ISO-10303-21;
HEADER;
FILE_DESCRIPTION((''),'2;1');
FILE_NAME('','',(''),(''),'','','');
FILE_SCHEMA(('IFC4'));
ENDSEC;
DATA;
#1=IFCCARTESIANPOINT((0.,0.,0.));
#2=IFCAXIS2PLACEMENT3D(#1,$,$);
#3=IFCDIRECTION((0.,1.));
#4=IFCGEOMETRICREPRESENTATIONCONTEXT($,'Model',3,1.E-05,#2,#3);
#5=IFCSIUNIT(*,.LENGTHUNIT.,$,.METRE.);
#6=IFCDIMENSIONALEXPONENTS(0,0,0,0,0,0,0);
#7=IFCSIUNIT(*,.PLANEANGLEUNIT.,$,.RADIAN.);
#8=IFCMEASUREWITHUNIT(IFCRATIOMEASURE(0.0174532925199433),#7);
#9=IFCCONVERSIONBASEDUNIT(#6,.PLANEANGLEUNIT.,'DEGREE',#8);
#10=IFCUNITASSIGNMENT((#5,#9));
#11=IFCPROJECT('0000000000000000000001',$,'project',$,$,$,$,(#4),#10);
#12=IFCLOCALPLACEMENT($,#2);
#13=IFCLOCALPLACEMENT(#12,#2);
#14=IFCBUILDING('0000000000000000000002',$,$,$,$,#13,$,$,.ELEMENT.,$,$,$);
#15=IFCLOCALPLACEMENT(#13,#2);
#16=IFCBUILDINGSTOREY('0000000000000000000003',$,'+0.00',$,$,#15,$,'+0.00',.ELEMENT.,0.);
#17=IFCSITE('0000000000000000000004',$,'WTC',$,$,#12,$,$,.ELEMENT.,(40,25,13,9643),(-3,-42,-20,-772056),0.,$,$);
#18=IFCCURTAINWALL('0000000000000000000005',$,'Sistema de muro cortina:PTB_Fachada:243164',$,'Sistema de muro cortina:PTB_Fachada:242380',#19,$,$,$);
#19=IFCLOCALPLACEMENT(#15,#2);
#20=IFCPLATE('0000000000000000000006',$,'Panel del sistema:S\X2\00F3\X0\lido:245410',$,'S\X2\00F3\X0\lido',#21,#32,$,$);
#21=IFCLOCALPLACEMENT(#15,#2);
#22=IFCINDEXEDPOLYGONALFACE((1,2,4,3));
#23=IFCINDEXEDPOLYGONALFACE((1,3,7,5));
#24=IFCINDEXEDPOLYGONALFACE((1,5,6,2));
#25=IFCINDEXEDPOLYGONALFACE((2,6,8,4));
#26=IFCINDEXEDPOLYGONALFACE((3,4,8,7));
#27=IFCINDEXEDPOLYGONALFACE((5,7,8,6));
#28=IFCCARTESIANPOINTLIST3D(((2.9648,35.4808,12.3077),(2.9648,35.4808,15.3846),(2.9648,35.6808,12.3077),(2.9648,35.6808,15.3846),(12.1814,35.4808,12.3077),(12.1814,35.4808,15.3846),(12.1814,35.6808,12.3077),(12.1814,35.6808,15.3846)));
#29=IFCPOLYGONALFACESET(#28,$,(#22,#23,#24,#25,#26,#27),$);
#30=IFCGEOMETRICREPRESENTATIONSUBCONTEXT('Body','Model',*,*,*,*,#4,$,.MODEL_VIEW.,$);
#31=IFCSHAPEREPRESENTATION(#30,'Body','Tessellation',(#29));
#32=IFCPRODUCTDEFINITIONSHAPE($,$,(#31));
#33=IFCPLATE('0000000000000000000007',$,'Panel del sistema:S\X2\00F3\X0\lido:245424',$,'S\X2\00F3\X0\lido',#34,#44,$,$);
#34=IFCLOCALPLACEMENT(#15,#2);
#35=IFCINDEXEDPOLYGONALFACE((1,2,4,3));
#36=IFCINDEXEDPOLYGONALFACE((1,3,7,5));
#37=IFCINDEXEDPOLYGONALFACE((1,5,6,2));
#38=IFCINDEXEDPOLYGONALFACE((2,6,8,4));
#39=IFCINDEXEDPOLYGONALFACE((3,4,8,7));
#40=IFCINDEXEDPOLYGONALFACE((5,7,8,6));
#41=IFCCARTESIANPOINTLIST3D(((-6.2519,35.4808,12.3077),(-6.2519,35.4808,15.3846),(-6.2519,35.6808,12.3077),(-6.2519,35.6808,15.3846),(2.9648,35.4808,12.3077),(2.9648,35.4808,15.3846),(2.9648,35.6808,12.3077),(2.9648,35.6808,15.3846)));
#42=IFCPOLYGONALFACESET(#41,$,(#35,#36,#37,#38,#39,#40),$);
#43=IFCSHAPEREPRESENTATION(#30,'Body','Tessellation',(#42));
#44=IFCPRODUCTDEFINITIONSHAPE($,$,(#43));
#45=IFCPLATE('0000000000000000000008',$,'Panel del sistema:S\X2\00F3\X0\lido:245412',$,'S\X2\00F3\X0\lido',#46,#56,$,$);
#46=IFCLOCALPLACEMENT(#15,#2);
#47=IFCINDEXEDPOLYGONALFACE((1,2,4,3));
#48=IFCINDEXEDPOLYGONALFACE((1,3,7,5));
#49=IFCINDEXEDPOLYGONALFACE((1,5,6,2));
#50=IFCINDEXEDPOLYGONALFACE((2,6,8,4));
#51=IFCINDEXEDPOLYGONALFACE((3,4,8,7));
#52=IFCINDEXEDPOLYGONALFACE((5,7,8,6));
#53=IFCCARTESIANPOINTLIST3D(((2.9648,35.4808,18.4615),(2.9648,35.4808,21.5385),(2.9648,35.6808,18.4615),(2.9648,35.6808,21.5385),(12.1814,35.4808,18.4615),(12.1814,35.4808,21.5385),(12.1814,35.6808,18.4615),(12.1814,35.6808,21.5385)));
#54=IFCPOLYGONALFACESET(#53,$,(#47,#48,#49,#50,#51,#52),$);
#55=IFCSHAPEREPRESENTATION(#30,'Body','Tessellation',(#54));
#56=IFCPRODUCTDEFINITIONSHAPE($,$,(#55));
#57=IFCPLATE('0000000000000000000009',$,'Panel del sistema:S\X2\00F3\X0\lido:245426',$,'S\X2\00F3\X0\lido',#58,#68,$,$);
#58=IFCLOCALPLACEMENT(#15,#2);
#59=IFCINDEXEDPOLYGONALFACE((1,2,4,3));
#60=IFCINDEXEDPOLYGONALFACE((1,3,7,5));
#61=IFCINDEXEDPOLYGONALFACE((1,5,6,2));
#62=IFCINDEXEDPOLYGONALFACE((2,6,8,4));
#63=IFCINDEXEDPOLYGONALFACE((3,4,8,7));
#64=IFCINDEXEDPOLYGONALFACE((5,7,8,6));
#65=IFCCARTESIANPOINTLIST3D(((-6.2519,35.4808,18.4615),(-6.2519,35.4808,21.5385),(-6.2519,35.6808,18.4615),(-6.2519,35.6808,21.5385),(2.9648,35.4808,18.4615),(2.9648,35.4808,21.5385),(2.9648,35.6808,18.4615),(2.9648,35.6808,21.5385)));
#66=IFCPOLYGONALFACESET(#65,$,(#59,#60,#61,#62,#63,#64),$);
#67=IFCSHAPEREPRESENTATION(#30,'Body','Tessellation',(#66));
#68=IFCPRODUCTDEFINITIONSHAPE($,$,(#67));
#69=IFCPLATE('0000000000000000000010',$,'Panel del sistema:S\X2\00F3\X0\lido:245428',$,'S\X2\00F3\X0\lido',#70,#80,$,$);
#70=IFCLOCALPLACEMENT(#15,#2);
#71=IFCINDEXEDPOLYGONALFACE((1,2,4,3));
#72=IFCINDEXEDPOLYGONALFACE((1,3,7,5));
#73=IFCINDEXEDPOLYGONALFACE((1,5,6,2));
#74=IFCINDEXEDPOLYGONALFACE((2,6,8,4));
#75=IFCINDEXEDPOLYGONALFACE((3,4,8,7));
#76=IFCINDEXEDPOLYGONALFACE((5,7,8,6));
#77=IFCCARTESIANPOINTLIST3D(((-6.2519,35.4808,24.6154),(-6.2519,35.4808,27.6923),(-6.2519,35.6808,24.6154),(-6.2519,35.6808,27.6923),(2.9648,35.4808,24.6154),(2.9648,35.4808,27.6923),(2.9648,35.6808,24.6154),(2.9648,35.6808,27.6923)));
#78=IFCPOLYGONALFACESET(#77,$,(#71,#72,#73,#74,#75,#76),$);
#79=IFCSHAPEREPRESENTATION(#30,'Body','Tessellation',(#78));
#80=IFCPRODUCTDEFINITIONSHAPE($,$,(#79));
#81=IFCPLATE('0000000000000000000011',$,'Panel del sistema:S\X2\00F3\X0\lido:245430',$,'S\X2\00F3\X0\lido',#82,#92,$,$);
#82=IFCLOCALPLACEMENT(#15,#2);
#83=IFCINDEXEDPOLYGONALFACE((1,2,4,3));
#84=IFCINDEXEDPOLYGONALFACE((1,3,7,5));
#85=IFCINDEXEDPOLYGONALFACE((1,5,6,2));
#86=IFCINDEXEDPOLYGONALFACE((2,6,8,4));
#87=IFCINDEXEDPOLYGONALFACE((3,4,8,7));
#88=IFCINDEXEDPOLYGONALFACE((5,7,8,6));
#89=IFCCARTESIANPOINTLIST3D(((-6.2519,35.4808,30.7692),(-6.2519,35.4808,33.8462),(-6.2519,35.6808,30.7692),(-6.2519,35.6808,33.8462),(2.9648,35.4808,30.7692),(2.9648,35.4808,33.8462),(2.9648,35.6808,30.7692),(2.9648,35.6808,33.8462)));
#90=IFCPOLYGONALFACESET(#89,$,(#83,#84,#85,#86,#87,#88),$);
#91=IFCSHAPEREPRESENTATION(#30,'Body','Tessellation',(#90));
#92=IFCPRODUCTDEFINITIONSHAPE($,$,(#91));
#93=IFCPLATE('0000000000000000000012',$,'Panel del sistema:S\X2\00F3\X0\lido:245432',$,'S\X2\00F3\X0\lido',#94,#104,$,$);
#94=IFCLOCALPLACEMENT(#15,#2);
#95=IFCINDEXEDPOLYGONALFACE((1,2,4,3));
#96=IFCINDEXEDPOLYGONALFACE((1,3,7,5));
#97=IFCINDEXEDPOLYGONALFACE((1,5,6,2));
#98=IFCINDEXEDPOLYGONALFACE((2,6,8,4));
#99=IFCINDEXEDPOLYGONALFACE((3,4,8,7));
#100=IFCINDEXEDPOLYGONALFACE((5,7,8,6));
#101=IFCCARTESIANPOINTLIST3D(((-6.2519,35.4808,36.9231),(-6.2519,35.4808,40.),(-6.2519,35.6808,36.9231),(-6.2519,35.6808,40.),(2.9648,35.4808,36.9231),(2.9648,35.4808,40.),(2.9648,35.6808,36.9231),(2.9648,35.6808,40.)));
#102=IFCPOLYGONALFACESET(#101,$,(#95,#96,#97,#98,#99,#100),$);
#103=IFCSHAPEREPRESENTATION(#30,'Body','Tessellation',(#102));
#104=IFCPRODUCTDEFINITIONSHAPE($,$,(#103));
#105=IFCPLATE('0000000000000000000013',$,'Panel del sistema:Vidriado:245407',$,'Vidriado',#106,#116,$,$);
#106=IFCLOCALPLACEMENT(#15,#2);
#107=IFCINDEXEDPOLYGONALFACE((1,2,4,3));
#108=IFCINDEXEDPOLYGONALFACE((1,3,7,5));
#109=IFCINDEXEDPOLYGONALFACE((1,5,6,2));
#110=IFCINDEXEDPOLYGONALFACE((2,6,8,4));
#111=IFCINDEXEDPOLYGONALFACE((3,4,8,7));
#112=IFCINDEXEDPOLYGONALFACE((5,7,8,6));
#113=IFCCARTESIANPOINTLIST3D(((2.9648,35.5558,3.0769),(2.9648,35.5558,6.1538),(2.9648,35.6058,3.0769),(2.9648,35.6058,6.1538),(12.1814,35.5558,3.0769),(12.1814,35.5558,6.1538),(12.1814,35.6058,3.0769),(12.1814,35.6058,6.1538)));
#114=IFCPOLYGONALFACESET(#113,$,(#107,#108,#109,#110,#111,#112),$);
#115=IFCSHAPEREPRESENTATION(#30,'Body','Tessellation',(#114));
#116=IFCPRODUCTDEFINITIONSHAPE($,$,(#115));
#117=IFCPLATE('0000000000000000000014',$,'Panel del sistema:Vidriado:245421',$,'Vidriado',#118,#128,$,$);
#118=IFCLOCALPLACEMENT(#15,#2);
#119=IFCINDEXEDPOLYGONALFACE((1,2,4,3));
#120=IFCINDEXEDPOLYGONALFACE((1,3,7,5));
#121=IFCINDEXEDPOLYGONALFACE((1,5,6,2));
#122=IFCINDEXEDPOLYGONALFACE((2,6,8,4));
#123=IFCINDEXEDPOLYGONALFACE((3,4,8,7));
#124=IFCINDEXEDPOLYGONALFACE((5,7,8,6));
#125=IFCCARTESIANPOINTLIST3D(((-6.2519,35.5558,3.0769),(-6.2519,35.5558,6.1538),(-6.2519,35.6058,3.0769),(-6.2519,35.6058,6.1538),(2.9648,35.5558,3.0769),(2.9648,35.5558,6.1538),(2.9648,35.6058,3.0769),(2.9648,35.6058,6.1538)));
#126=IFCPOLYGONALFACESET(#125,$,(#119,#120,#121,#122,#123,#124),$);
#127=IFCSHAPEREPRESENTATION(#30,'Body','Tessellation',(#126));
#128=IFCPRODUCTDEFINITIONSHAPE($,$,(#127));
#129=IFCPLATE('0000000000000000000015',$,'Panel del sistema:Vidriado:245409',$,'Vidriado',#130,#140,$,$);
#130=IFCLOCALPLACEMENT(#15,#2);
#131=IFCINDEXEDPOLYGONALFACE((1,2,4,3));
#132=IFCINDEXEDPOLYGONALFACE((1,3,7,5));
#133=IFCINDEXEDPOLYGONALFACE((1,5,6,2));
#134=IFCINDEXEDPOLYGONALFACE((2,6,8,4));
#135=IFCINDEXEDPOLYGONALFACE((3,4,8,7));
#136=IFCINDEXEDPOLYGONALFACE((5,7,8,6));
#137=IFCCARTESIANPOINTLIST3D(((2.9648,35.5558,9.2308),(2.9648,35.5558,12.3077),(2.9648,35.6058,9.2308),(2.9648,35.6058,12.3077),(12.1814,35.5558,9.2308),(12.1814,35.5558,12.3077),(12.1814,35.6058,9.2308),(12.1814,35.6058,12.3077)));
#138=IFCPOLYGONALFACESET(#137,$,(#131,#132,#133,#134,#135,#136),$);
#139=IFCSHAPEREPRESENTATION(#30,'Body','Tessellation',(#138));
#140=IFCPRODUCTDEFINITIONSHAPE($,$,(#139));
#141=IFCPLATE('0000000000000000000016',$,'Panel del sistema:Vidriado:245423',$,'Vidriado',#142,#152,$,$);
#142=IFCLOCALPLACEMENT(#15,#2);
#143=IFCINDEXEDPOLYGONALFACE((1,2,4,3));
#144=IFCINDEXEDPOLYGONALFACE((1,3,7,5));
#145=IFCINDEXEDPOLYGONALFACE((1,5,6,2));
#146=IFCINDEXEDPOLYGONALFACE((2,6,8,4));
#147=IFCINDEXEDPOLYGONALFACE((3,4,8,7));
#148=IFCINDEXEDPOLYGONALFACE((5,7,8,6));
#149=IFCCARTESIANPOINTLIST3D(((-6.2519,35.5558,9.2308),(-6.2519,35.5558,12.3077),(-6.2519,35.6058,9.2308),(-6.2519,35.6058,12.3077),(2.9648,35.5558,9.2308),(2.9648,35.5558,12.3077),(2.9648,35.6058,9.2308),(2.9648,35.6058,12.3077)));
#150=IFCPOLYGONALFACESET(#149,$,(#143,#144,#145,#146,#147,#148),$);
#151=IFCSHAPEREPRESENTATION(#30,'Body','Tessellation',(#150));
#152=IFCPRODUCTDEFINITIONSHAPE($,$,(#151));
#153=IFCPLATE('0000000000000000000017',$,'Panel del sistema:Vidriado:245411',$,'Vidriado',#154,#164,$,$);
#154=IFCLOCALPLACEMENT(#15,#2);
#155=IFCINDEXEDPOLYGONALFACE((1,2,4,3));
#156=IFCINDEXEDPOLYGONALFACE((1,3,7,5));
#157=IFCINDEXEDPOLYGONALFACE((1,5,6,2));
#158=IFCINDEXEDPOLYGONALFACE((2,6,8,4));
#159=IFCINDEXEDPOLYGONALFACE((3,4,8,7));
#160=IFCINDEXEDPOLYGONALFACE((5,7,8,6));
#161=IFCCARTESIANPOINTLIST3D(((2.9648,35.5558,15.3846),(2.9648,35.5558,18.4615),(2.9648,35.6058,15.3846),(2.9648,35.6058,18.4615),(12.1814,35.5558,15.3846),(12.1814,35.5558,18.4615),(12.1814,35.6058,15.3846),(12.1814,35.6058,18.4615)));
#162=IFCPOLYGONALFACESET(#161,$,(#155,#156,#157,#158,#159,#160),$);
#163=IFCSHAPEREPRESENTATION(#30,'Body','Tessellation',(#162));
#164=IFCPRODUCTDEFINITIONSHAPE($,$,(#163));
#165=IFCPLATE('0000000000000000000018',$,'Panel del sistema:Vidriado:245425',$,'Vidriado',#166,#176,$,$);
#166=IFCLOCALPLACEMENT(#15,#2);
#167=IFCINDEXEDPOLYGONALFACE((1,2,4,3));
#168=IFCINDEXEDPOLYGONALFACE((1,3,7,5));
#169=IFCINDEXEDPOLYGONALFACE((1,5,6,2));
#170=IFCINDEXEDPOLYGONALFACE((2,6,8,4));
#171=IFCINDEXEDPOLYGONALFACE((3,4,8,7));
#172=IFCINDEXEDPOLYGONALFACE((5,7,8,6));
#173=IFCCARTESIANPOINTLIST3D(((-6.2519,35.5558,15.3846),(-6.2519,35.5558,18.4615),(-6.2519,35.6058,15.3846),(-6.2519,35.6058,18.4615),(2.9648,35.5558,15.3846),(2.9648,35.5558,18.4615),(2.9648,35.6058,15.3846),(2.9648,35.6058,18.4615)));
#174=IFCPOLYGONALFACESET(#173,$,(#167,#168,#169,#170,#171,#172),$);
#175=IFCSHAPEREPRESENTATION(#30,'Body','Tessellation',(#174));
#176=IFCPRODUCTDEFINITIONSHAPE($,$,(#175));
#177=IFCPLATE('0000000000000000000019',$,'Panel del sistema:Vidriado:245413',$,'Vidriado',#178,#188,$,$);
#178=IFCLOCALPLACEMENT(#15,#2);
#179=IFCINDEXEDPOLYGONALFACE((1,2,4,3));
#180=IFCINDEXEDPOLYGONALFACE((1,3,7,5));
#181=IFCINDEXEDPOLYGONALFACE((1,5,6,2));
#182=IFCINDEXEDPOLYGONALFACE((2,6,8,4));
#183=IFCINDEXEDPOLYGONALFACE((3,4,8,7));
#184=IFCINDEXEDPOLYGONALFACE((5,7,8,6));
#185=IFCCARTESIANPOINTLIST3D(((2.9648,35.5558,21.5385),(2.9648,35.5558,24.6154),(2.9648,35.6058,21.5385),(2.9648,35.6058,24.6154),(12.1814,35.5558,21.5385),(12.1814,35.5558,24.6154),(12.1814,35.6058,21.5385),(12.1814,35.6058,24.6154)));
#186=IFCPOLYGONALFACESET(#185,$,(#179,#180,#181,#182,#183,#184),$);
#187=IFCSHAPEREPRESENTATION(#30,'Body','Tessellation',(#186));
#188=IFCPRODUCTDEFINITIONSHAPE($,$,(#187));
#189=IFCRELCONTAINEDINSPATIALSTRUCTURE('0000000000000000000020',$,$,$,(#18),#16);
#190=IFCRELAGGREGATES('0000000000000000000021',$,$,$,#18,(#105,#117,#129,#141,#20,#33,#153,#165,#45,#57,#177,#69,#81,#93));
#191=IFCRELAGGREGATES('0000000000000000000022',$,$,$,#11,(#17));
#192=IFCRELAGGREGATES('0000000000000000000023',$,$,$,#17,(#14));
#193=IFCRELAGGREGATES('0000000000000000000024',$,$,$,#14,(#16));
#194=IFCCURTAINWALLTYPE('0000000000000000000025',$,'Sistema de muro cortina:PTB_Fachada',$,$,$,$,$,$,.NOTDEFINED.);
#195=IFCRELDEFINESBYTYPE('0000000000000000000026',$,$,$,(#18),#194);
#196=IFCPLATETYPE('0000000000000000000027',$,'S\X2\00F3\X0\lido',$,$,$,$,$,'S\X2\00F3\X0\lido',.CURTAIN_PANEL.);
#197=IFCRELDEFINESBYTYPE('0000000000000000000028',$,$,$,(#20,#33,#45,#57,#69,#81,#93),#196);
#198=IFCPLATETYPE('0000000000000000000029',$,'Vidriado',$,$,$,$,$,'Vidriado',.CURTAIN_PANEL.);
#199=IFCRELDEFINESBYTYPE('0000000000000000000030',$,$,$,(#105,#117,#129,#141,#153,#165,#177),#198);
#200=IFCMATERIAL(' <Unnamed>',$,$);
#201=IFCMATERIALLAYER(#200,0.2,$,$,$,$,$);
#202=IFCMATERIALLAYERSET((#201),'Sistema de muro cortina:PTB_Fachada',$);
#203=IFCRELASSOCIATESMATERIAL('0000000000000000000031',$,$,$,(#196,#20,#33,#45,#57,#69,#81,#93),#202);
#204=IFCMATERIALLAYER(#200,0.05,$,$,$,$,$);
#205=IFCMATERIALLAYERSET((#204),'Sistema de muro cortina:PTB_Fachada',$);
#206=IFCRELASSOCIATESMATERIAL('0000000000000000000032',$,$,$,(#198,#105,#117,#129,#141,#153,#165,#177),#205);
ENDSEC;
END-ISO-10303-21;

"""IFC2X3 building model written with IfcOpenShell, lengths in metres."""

from ifc_helpers import new_model, entity, si_unit, converted_unit, direction, frame, origin, origin_2d_with_axis, place, context, subcontext, project, spatial, rectangle, extrude, source, transform, mapped, material, layer, layer_set, layer_usage, type_object, type_shapes, element, aggregate, save


model = new_model("IFC2X3")

# Units and contexts
model_context = context("Model", 3, precision=1e-05, world=origin(), true_north=direction((0.0, 1.0)))
body_context = subcontext(model_context, "Body", "Model", "MODEL_VIEW")
ifc_project = project(units=[si_unit("LENGTHUNIT", "METRE"), converted_unit("PLANEANGLEUNIT", "DEGREE", entity("IfcRatioMeasure", 0.0174532925199433), si_unit("PLANEANGLEUNIT", "RADIAN"), dimensions=[0, 0, 0, 0, 0, 0, 0])], contexts=[model_context])

# Site, building, storey
site_placement = place(None, origin())
site = spatial("IfcSite", under=ifc_project, at=site_placement, Name="WTC", CompositionType="ELEMENT", RefLatitude=(40, 25, 13, 9643), RefLongitude=(-3, -42, -20, -772056), RefElevation=0.0)
building_placement = place(site_placement, origin())
building = spatial("IfcBuilding", under=site, at=building_placement, CompositionType="ELEMENT")
storey_placement = place(building_placement, origin())
storey = spatial("IfcBuildingStorey", under=building, at=storey_placement, Name="+0.00", LongName="+0.00", CompositionType="ELEMENT", Elevation=0.0)

# Curtain wall, plates
curtain_wall_type = type_object("IfcCurtainWallType", Name="Sistema de muro cortina:PTB_Fachada", PredefinedType="NOTDEFINED")
ifc_material_1 = material(Name=" <Unnamed>")
ifc_layer_1 = layer(ifc_material_1, 0.2)
ifc_layer_set_1 = layer_set([ifc_layer_1], Name="Sistema de muro cortina:PTB_Fachada")
ifc_layer_2 = layer(ifc_material_1, 0.05)
ifc_layer_set_2 = layer_set([ifc_layer_2], Name="Sistema de muro cortina:PTB_Fachada")
curtain_wall_1_placement = place(storey_placement, origin())
curtain_wall_1 = element("IfcCurtainWall", 1, at=curtain_wall_1_placement, inside=storey, type_object=curtain_wall_type, Name="Sistema de muro cortina:PTB_Fachada:243164", ObjectType="Sistema de muro cortina:PTB_Fachada:242380")
plate_type_1 = type_object("IfcPlateType", Name="Sólido", ElementType="Sólido", PredefinedType="CURTAIN_PANEL", material=ifc_layer_set_1)
shared_shape_1 = source(origin(), body_context, "Body", "SweptSolid", [
    extrude(rectangle(XDim=0.2, YDim=9.2166, at=origin_2d_with_axis()), frame((0.0, 0.0, 0.0), z_axis=(0.0, 0.0, 1.0), x_axis=(0.0, 1.0, 0.0)), (0.0, 0.0, 1.0), 3.0769),
])
type_shapes(plate_type_1, [shared_shape_1])
ifc_layer_usage_1 = layer_usage(ifc_layer_set_1, "AXIS3", "POSITIVE", 0.0)
plate_1_placement = place(curtain_wall_1_placement, frame((7.5731, 35.5808, 12.3077), z_axis=(0.0, 0.0, 1.0), x_axis=(-1.0, 0.0, 0.0)))
plate_1 = element("IfcPlate", 2, at=plate_1_placement, type_object=plate_type_1, material=ifc_layer_usage_1, Name="Panel del sistema:Sólido:245410", ObjectType="Sólido", context=body_context, shape_type="MappedRepresentation", body=[
    mapped(shared_shape_1, transform((0.0, 0.0, 0.0), scale=1.0)),
])
ifc_layer_usage_2 = layer_usage(ifc_layer_set_1, "AXIS3", "POSITIVE", 0.0)
plate_2_placement = place(curtain_wall_1_placement, frame((-1.6436, 35.5808, 12.3077), z_axis=(0.0, 0.0, 1.0), x_axis=(-1.0, 0.0, 0.0)))
plate_2 = element("IfcPlate", 3, at=plate_2_placement, type_object=plate_type_1, material=ifc_layer_usage_2, Name="Panel del sistema:Sólido:245424", ObjectType="Sólido", context=body_context, shape_type="MappedRepresentation", body=[
    mapped(shared_shape_1, transform((0.0, 0.0, 0.0), scale=1.0)),
])
ifc_layer_usage_3 = layer_usage(ifc_layer_set_1, "AXIS3", "POSITIVE", 0.0)
plate_3_placement = place(curtain_wall_1_placement, frame((7.5731, 35.5808, 18.4615), z_axis=(0.0, 0.0, 1.0), x_axis=(-1.0, 0.0, 0.0)))
plate_3 = element("IfcPlate", 4, at=plate_3_placement, type_object=plate_type_1, material=ifc_layer_usage_3, Name="Panel del sistema:Sólido:245412", ObjectType="Sólido", context=body_context, shape_type="MappedRepresentation", body=[
    mapped(shared_shape_1, transform((0.0, 0.0, 0.0), scale=1.0)),
])
ifc_layer_usage_4 = layer_usage(ifc_layer_set_1, "AXIS3", "POSITIVE", 0.0)
plate_4_placement = place(curtain_wall_1_placement, frame((-1.6436, 35.5808, 18.4615), z_axis=(0.0, 0.0, 1.0), x_axis=(-1.0, 0.0, 0.0)))
plate_4 = element("IfcPlate", 5, at=plate_4_placement, type_object=plate_type_1, material=ifc_layer_usage_4, Name="Panel del sistema:Sólido:245426", ObjectType="Sólido", context=body_context, shape_type="MappedRepresentation", body=[
    mapped(shared_shape_1, transform((0.0, 0.0, 0.0), scale=1.0)),
])
ifc_layer_usage_5 = layer_usage(ifc_layer_set_1, "AXIS3", "POSITIVE", 0.0)
plate_5_placement = place(curtain_wall_1_placement, frame((-1.6436, 35.5808, 24.6154), z_axis=(0.0, 0.0, 1.0), x_axis=(-1.0, 0.0, 0.0)))
plate_5 = element("IfcPlate", 6, at=plate_5_placement, type_object=plate_type_1, material=ifc_layer_usage_5, Name="Panel del sistema:Sólido:245428", ObjectType="Sólido", context=body_context, shape_type="MappedRepresentation", body=[
    mapped(shared_shape_1, transform((0.0, 0.0, 0.0), scale=1.0)),
])
ifc_layer_usage_6 = layer_usage(ifc_layer_set_1, "AXIS3", "POSITIVE", 0.0)
plate_6_placement = place(curtain_wall_1_placement, frame((-1.6436, 35.5808, 30.7692), z_axis=(0.0, 0.0, 1.0), x_axis=(-1.0, 0.0, 0.0)))
plate_6 = element("IfcPlate", 7, at=plate_6_placement, type_object=plate_type_1, material=ifc_layer_usage_6, Name="Panel del sistema:Sólido:245430", ObjectType="Sólido", context=body_context, shape_type="MappedRepresentation", body=[
    mapped(shared_shape_1, transform((0.0, 0.0, 0.0), scale=1.0)),
])
ifc_layer_usage_7 = layer_usage(ifc_layer_set_1, "AXIS3", "POSITIVE", 0.0)
plate_7_placement = place(curtain_wall_1_placement, frame((-1.6436, 35.5808, 36.9231), z_axis=(0.0, 0.0, 1.0), x_axis=(-1.0, 0.0, 0.0)))
plate_7 = element("IfcPlate", 8, at=plate_7_placement, type_object=plate_type_1, material=ifc_layer_usage_7, Name="Panel del sistema:Sólido:245432", ObjectType="Sólido", context=body_context, shape_type="MappedRepresentation", body=[
    mapped(shared_shape_1, transform((0.0, 0.0, 0.0), scale=1.0)),
])
ifc_layer_usage_8 = layer_usage(ifc_layer_set_2, "AXIS3", "POSITIVE", 0.0)
plate_type_2 = type_object("IfcPlateType", Name="Vidriado", ElementType="Vidriado", PredefinedType="CURTAIN_PANEL", material=ifc_layer_set_2)
shared_shape_2 = source(origin(), body_context, "Body", "SweptSolid", [
    extrude(rectangle(XDim=0.05, YDim=9.2166, at=origin_2d_with_axis()), frame((0.0, 0.0, 0.0), z_axis=(0.0, 0.0, 1.0), x_axis=(0.0, 1.0, 0.0)), (0.0, 0.0, 1.0), 3.0769),
])
type_shapes(plate_type_2, [shared_shape_2])
plate_8_placement = place(curtain_wall_1_placement, frame((7.5731, 35.5808, 3.0769), z_axis=(0.0, 0.0, 1.0), x_axis=(-1.0, 0.0, 0.0)))
plate_8 = element("IfcPlate", 9, at=plate_8_placement, type_object=plate_type_2, material=ifc_layer_usage_8, Name="Panel del sistema:Vidriado:245407", ObjectType="Vidriado", context=body_context, shape_type="MappedRepresentation", body=[
    mapped(shared_shape_2, transform((0.0, 0.0, 0.0), scale=1.0)),
])
ifc_layer_usage_9 = layer_usage(ifc_layer_set_2, "AXIS3", "POSITIVE", 0.0)
plate_9_placement = place(curtain_wall_1_placement, frame((-1.6436, 35.5808, 3.0769), z_axis=(0.0, 0.0, 1.0), x_axis=(-1.0, 0.0, 0.0)))
plate_9 = element("IfcPlate", 10, at=plate_9_placement, type_object=plate_type_2, material=ifc_layer_usage_9, Name="Panel del sistema:Vidriado:245421", ObjectType="Vidriado", context=body_context, shape_type="MappedRepresentation", body=[
    mapped(shared_shape_2, transform((0.0, 0.0, 0.0), scale=1.0)),
])
ifc_layer_usage_10 = layer_usage(ifc_layer_set_2, "AXIS3", "POSITIVE", 0.0)
plate_10_placement = place(curtain_wall_1_placement, frame((7.5731, 35.5808, 9.2308), z_axis=(0.0, 0.0, 1.0), x_axis=(-1.0, 0.0, 0.0)))
plate_10 = element("IfcPlate", 11, at=plate_10_placement, type_object=plate_type_2, material=ifc_layer_usage_10, Name="Panel del sistema:Vidriado:245409", ObjectType="Vidriado", context=body_context, shape_type="MappedRepresentation", body=[
    mapped(shared_shape_2, transform((0.0, 0.0, 0.0), scale=1.0)),
])
ifc_layer_usage_11 = layer_usage(ifc_layer_set_2, "AXIS3", "POSITIVE", 0.0)
plate_11_placement = place(curtain_wall_1_placement, frame((-1.6436, 35.5808, 9.2308), z_axis=(0.0, 0.0, 1.0), x_axis=(-1.0, 0.0, 0.0)))
plate_11 = element("IfcPlate", 12, at=plate_11_placement, type_object=plate_type_2, material=ifc_layer_usage_11, Name="Panel del sistema:Vidriado:245423", ObjectType="Vidriado", context=body_context, shape_type="MappedRepresentation", body=[
    mapped(shared_shape_2, transform((0.0, 0.0, 0.0), scale=1.0)),
])
ifc_layer_usage_12 = layer_usage(ifc_layer_set_2, "AXIS3", "POSITIVE", 0.0)
plate_12_placement = place(curtain_wall_1_placement, frame((7.5731, 35.5808, 15.3846), z_axis=(0.0, 0.0, 1.0), x_axis=(-1.0, 0.0, 0.0)))
plate_12 = element("IfcPlate", 13, at=plate_12_placement, type_object=plate_type_2, material=ifc_layer_usage_12, Name="Panel del sistema:Vidriado:245411", ObjectType="Vidriado", context=body_context, shape_type="MappedRepresentation", body=[
    mapped(shared_shape_2, transform((0.0, 0.0, 0.0), scale=1.0)),
])
ifc_layer_usage_13 = layer_usage(ifc_layer_set_2, "AXIS3", "POSITIVE", 0.0)
plate_13_placement = place(curtain_wall_1_placement, frame((-1.6436, 35.5808, 15.3846), z_axis=(0.0, 0.0, 1.0), x_axis=(-1.0, 0.0, 0.0)))
plate_13 = element("IfcPlate", 14, at=plate_13_placement, type_object=plate_type_2, material=ifc_layer_usage_13, Name="Panel del sistema:Vidriado:245425", ObjectType="Vidriado", context=body_context, shape_type="MappedRepresentation", body=[
    mapped(shared_shape_2, transform((0.0, 0.0, 0.0), scale=1.0)),
])
ifc_layer_usage_14 = layer_usage(ifc_layer_set_2, "AXIS3", "POSITIVE", 0.0)
plate_14_placement = place(curtain_wall_1_placement, frame((7.5731, 35.5808, 21.5385), z_axis=(0.0, 0.0, 1.0), x_axis=(-1.0, 0.0, 0.0)))
plate_14 = element("IfcPlate", 15, at=plate_14_placement, type_object=plate_type_2, material=ifc_layer_usage_14, Name="Panel del sistema:Vidriado:245413", ObjectType="Vidriado", context=body_context, shape_type="MappedRepresentation", body=[
    mapped(shared_shape_2, transform((0.0, 0.0, 0.0), scale=1.0)),
])
aggregate(curtain_wall_1, [plate_8, plate_9, plate_10, plate_11, plate_1, plate_2, plate_12, plate_13, plate_3, plate_4, plate_14, plate_5, plate_6, plate_7])

save(model, "model.ifc")
